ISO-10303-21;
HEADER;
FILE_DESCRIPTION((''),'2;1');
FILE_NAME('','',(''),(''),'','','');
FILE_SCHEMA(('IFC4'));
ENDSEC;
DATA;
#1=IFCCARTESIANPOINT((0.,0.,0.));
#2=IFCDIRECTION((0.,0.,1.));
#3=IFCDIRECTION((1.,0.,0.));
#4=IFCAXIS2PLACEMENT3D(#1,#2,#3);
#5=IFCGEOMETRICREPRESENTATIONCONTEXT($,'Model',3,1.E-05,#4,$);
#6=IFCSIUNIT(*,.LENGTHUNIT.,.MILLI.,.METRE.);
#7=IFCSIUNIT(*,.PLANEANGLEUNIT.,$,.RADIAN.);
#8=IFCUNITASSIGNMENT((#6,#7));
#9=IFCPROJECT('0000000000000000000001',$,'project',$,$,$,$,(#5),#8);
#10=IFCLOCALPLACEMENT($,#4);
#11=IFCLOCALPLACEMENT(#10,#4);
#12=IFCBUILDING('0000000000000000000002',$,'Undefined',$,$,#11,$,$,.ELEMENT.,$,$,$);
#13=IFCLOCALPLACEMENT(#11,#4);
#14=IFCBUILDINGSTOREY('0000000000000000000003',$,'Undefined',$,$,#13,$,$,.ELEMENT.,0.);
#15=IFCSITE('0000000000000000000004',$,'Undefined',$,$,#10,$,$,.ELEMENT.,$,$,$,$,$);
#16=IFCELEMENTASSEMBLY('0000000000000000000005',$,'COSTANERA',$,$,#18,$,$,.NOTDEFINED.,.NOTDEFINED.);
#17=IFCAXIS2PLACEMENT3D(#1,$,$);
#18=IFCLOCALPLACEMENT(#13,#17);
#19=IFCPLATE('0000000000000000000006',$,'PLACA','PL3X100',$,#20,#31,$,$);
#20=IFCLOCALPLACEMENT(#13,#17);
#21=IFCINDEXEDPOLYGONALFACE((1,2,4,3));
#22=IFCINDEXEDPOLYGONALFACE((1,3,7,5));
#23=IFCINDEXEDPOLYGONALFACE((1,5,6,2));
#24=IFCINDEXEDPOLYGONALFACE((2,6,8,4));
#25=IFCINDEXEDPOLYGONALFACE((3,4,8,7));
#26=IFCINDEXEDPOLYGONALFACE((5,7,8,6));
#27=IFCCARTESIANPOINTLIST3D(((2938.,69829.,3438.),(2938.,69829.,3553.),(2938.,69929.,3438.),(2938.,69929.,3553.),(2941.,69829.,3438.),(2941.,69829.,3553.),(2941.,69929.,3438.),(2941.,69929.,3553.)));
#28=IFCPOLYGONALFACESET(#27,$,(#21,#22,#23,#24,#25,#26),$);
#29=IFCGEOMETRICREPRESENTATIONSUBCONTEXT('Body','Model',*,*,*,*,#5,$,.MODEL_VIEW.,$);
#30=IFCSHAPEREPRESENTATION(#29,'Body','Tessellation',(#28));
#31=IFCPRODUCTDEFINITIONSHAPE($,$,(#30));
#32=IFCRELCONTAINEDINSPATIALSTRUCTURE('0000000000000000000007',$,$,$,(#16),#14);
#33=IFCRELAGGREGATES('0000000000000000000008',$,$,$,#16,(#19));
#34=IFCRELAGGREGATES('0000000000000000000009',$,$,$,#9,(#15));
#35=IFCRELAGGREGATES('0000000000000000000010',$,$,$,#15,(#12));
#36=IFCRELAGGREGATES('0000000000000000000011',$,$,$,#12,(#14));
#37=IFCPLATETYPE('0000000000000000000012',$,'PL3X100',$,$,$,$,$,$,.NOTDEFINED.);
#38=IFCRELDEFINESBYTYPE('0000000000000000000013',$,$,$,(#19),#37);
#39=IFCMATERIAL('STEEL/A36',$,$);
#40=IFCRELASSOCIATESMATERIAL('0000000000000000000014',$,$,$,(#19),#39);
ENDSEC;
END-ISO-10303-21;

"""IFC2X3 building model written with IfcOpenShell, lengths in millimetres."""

from ifc_helpers import new_model, si_unit, frame, origin_with_axes, place, context, subcontext, project, spatial, polyline, outline, extrude, material, type_object, element, aggregate, save


model = new_model("IFC2X3")

# Units and contexts
model_context = context("Model", 3, precision=1e-05, world=origin_with_axes())
body_context = subcontext(model_context, "Body", "Model", "MODEL_VIEW")
ifc_project = project(units=[si_unit("LENGTHUNIT", "METRE", prefix="MILLI"), si_unit("PLANEANGLEUNIT", "RADIAN")], contexts=[model_context])

# Site, building, storey
site_placement = place(None, origin_with_axes())
site = spatial("IfcSite", under=ifc_project, at=site_placement, Name="Undefined", CompositionType="ELEMENT")
building_placement = place(site_placement, origin_with_axes())
building = spatial("IfcBuilding", under=site, at=building_placement, Name="Undefined", CompositionType="ELEMENT")
storey_placement = place(building_placement, origin_with_axes())
storey = spatial("IfcBuildingStorey", under=building, at=storey_placement, Name="Undefined", CompositionType="ELEMENT", Elevation=0.0)

# Shared definitions
ifc_material_1 = material(Name="STEEL/A36")

# Element assembly
assembly_1_placement = place(storey_placement, origin_with_axes())
assembly_1 = element("IfcElementAssembly", 1, at=assembly_1_placement, inside=storey, Name="COSTANERA", AssemblyPlace="NOTDEFINED", PredefinedType="NOTDEFINED")

# Plate
plate_type_1 = type_object("IfcPlateType", Name="PL3X100", PredefinedType="NOTDEFINED")
plate_1_placement = place(assembly_1_placement, frame((2939.5, 69829.0, 3438.0), z_axis=(1.0, 0.0, 0.0), x_axis=(0.0, 1.0, 0.0)))
plate_1 = element("IfcPlate", 2, at=plate_1_placement, type_object=plate_type_1, material=ifc_material_1, Name="PLACA", Description="PL3X100", context=body_context, shape_type="SweptSolid", body=[
    extrude(outline(polyline([(0.0, 0.0), (100.0, 0.0), (100.0, 115.0), (0.0, 115.0), (0.0, 0.0)])), frame((0.0, 0.0, -1.5), z_axis=(0.0, 0.0, 1.0), x_axis=(1.0, 0.0, 0.0)), (0.0, 0.0, 1.0), 3.0),
])

aggregate(assembly_1, [plate_1])

save(model, "model.ifc")
